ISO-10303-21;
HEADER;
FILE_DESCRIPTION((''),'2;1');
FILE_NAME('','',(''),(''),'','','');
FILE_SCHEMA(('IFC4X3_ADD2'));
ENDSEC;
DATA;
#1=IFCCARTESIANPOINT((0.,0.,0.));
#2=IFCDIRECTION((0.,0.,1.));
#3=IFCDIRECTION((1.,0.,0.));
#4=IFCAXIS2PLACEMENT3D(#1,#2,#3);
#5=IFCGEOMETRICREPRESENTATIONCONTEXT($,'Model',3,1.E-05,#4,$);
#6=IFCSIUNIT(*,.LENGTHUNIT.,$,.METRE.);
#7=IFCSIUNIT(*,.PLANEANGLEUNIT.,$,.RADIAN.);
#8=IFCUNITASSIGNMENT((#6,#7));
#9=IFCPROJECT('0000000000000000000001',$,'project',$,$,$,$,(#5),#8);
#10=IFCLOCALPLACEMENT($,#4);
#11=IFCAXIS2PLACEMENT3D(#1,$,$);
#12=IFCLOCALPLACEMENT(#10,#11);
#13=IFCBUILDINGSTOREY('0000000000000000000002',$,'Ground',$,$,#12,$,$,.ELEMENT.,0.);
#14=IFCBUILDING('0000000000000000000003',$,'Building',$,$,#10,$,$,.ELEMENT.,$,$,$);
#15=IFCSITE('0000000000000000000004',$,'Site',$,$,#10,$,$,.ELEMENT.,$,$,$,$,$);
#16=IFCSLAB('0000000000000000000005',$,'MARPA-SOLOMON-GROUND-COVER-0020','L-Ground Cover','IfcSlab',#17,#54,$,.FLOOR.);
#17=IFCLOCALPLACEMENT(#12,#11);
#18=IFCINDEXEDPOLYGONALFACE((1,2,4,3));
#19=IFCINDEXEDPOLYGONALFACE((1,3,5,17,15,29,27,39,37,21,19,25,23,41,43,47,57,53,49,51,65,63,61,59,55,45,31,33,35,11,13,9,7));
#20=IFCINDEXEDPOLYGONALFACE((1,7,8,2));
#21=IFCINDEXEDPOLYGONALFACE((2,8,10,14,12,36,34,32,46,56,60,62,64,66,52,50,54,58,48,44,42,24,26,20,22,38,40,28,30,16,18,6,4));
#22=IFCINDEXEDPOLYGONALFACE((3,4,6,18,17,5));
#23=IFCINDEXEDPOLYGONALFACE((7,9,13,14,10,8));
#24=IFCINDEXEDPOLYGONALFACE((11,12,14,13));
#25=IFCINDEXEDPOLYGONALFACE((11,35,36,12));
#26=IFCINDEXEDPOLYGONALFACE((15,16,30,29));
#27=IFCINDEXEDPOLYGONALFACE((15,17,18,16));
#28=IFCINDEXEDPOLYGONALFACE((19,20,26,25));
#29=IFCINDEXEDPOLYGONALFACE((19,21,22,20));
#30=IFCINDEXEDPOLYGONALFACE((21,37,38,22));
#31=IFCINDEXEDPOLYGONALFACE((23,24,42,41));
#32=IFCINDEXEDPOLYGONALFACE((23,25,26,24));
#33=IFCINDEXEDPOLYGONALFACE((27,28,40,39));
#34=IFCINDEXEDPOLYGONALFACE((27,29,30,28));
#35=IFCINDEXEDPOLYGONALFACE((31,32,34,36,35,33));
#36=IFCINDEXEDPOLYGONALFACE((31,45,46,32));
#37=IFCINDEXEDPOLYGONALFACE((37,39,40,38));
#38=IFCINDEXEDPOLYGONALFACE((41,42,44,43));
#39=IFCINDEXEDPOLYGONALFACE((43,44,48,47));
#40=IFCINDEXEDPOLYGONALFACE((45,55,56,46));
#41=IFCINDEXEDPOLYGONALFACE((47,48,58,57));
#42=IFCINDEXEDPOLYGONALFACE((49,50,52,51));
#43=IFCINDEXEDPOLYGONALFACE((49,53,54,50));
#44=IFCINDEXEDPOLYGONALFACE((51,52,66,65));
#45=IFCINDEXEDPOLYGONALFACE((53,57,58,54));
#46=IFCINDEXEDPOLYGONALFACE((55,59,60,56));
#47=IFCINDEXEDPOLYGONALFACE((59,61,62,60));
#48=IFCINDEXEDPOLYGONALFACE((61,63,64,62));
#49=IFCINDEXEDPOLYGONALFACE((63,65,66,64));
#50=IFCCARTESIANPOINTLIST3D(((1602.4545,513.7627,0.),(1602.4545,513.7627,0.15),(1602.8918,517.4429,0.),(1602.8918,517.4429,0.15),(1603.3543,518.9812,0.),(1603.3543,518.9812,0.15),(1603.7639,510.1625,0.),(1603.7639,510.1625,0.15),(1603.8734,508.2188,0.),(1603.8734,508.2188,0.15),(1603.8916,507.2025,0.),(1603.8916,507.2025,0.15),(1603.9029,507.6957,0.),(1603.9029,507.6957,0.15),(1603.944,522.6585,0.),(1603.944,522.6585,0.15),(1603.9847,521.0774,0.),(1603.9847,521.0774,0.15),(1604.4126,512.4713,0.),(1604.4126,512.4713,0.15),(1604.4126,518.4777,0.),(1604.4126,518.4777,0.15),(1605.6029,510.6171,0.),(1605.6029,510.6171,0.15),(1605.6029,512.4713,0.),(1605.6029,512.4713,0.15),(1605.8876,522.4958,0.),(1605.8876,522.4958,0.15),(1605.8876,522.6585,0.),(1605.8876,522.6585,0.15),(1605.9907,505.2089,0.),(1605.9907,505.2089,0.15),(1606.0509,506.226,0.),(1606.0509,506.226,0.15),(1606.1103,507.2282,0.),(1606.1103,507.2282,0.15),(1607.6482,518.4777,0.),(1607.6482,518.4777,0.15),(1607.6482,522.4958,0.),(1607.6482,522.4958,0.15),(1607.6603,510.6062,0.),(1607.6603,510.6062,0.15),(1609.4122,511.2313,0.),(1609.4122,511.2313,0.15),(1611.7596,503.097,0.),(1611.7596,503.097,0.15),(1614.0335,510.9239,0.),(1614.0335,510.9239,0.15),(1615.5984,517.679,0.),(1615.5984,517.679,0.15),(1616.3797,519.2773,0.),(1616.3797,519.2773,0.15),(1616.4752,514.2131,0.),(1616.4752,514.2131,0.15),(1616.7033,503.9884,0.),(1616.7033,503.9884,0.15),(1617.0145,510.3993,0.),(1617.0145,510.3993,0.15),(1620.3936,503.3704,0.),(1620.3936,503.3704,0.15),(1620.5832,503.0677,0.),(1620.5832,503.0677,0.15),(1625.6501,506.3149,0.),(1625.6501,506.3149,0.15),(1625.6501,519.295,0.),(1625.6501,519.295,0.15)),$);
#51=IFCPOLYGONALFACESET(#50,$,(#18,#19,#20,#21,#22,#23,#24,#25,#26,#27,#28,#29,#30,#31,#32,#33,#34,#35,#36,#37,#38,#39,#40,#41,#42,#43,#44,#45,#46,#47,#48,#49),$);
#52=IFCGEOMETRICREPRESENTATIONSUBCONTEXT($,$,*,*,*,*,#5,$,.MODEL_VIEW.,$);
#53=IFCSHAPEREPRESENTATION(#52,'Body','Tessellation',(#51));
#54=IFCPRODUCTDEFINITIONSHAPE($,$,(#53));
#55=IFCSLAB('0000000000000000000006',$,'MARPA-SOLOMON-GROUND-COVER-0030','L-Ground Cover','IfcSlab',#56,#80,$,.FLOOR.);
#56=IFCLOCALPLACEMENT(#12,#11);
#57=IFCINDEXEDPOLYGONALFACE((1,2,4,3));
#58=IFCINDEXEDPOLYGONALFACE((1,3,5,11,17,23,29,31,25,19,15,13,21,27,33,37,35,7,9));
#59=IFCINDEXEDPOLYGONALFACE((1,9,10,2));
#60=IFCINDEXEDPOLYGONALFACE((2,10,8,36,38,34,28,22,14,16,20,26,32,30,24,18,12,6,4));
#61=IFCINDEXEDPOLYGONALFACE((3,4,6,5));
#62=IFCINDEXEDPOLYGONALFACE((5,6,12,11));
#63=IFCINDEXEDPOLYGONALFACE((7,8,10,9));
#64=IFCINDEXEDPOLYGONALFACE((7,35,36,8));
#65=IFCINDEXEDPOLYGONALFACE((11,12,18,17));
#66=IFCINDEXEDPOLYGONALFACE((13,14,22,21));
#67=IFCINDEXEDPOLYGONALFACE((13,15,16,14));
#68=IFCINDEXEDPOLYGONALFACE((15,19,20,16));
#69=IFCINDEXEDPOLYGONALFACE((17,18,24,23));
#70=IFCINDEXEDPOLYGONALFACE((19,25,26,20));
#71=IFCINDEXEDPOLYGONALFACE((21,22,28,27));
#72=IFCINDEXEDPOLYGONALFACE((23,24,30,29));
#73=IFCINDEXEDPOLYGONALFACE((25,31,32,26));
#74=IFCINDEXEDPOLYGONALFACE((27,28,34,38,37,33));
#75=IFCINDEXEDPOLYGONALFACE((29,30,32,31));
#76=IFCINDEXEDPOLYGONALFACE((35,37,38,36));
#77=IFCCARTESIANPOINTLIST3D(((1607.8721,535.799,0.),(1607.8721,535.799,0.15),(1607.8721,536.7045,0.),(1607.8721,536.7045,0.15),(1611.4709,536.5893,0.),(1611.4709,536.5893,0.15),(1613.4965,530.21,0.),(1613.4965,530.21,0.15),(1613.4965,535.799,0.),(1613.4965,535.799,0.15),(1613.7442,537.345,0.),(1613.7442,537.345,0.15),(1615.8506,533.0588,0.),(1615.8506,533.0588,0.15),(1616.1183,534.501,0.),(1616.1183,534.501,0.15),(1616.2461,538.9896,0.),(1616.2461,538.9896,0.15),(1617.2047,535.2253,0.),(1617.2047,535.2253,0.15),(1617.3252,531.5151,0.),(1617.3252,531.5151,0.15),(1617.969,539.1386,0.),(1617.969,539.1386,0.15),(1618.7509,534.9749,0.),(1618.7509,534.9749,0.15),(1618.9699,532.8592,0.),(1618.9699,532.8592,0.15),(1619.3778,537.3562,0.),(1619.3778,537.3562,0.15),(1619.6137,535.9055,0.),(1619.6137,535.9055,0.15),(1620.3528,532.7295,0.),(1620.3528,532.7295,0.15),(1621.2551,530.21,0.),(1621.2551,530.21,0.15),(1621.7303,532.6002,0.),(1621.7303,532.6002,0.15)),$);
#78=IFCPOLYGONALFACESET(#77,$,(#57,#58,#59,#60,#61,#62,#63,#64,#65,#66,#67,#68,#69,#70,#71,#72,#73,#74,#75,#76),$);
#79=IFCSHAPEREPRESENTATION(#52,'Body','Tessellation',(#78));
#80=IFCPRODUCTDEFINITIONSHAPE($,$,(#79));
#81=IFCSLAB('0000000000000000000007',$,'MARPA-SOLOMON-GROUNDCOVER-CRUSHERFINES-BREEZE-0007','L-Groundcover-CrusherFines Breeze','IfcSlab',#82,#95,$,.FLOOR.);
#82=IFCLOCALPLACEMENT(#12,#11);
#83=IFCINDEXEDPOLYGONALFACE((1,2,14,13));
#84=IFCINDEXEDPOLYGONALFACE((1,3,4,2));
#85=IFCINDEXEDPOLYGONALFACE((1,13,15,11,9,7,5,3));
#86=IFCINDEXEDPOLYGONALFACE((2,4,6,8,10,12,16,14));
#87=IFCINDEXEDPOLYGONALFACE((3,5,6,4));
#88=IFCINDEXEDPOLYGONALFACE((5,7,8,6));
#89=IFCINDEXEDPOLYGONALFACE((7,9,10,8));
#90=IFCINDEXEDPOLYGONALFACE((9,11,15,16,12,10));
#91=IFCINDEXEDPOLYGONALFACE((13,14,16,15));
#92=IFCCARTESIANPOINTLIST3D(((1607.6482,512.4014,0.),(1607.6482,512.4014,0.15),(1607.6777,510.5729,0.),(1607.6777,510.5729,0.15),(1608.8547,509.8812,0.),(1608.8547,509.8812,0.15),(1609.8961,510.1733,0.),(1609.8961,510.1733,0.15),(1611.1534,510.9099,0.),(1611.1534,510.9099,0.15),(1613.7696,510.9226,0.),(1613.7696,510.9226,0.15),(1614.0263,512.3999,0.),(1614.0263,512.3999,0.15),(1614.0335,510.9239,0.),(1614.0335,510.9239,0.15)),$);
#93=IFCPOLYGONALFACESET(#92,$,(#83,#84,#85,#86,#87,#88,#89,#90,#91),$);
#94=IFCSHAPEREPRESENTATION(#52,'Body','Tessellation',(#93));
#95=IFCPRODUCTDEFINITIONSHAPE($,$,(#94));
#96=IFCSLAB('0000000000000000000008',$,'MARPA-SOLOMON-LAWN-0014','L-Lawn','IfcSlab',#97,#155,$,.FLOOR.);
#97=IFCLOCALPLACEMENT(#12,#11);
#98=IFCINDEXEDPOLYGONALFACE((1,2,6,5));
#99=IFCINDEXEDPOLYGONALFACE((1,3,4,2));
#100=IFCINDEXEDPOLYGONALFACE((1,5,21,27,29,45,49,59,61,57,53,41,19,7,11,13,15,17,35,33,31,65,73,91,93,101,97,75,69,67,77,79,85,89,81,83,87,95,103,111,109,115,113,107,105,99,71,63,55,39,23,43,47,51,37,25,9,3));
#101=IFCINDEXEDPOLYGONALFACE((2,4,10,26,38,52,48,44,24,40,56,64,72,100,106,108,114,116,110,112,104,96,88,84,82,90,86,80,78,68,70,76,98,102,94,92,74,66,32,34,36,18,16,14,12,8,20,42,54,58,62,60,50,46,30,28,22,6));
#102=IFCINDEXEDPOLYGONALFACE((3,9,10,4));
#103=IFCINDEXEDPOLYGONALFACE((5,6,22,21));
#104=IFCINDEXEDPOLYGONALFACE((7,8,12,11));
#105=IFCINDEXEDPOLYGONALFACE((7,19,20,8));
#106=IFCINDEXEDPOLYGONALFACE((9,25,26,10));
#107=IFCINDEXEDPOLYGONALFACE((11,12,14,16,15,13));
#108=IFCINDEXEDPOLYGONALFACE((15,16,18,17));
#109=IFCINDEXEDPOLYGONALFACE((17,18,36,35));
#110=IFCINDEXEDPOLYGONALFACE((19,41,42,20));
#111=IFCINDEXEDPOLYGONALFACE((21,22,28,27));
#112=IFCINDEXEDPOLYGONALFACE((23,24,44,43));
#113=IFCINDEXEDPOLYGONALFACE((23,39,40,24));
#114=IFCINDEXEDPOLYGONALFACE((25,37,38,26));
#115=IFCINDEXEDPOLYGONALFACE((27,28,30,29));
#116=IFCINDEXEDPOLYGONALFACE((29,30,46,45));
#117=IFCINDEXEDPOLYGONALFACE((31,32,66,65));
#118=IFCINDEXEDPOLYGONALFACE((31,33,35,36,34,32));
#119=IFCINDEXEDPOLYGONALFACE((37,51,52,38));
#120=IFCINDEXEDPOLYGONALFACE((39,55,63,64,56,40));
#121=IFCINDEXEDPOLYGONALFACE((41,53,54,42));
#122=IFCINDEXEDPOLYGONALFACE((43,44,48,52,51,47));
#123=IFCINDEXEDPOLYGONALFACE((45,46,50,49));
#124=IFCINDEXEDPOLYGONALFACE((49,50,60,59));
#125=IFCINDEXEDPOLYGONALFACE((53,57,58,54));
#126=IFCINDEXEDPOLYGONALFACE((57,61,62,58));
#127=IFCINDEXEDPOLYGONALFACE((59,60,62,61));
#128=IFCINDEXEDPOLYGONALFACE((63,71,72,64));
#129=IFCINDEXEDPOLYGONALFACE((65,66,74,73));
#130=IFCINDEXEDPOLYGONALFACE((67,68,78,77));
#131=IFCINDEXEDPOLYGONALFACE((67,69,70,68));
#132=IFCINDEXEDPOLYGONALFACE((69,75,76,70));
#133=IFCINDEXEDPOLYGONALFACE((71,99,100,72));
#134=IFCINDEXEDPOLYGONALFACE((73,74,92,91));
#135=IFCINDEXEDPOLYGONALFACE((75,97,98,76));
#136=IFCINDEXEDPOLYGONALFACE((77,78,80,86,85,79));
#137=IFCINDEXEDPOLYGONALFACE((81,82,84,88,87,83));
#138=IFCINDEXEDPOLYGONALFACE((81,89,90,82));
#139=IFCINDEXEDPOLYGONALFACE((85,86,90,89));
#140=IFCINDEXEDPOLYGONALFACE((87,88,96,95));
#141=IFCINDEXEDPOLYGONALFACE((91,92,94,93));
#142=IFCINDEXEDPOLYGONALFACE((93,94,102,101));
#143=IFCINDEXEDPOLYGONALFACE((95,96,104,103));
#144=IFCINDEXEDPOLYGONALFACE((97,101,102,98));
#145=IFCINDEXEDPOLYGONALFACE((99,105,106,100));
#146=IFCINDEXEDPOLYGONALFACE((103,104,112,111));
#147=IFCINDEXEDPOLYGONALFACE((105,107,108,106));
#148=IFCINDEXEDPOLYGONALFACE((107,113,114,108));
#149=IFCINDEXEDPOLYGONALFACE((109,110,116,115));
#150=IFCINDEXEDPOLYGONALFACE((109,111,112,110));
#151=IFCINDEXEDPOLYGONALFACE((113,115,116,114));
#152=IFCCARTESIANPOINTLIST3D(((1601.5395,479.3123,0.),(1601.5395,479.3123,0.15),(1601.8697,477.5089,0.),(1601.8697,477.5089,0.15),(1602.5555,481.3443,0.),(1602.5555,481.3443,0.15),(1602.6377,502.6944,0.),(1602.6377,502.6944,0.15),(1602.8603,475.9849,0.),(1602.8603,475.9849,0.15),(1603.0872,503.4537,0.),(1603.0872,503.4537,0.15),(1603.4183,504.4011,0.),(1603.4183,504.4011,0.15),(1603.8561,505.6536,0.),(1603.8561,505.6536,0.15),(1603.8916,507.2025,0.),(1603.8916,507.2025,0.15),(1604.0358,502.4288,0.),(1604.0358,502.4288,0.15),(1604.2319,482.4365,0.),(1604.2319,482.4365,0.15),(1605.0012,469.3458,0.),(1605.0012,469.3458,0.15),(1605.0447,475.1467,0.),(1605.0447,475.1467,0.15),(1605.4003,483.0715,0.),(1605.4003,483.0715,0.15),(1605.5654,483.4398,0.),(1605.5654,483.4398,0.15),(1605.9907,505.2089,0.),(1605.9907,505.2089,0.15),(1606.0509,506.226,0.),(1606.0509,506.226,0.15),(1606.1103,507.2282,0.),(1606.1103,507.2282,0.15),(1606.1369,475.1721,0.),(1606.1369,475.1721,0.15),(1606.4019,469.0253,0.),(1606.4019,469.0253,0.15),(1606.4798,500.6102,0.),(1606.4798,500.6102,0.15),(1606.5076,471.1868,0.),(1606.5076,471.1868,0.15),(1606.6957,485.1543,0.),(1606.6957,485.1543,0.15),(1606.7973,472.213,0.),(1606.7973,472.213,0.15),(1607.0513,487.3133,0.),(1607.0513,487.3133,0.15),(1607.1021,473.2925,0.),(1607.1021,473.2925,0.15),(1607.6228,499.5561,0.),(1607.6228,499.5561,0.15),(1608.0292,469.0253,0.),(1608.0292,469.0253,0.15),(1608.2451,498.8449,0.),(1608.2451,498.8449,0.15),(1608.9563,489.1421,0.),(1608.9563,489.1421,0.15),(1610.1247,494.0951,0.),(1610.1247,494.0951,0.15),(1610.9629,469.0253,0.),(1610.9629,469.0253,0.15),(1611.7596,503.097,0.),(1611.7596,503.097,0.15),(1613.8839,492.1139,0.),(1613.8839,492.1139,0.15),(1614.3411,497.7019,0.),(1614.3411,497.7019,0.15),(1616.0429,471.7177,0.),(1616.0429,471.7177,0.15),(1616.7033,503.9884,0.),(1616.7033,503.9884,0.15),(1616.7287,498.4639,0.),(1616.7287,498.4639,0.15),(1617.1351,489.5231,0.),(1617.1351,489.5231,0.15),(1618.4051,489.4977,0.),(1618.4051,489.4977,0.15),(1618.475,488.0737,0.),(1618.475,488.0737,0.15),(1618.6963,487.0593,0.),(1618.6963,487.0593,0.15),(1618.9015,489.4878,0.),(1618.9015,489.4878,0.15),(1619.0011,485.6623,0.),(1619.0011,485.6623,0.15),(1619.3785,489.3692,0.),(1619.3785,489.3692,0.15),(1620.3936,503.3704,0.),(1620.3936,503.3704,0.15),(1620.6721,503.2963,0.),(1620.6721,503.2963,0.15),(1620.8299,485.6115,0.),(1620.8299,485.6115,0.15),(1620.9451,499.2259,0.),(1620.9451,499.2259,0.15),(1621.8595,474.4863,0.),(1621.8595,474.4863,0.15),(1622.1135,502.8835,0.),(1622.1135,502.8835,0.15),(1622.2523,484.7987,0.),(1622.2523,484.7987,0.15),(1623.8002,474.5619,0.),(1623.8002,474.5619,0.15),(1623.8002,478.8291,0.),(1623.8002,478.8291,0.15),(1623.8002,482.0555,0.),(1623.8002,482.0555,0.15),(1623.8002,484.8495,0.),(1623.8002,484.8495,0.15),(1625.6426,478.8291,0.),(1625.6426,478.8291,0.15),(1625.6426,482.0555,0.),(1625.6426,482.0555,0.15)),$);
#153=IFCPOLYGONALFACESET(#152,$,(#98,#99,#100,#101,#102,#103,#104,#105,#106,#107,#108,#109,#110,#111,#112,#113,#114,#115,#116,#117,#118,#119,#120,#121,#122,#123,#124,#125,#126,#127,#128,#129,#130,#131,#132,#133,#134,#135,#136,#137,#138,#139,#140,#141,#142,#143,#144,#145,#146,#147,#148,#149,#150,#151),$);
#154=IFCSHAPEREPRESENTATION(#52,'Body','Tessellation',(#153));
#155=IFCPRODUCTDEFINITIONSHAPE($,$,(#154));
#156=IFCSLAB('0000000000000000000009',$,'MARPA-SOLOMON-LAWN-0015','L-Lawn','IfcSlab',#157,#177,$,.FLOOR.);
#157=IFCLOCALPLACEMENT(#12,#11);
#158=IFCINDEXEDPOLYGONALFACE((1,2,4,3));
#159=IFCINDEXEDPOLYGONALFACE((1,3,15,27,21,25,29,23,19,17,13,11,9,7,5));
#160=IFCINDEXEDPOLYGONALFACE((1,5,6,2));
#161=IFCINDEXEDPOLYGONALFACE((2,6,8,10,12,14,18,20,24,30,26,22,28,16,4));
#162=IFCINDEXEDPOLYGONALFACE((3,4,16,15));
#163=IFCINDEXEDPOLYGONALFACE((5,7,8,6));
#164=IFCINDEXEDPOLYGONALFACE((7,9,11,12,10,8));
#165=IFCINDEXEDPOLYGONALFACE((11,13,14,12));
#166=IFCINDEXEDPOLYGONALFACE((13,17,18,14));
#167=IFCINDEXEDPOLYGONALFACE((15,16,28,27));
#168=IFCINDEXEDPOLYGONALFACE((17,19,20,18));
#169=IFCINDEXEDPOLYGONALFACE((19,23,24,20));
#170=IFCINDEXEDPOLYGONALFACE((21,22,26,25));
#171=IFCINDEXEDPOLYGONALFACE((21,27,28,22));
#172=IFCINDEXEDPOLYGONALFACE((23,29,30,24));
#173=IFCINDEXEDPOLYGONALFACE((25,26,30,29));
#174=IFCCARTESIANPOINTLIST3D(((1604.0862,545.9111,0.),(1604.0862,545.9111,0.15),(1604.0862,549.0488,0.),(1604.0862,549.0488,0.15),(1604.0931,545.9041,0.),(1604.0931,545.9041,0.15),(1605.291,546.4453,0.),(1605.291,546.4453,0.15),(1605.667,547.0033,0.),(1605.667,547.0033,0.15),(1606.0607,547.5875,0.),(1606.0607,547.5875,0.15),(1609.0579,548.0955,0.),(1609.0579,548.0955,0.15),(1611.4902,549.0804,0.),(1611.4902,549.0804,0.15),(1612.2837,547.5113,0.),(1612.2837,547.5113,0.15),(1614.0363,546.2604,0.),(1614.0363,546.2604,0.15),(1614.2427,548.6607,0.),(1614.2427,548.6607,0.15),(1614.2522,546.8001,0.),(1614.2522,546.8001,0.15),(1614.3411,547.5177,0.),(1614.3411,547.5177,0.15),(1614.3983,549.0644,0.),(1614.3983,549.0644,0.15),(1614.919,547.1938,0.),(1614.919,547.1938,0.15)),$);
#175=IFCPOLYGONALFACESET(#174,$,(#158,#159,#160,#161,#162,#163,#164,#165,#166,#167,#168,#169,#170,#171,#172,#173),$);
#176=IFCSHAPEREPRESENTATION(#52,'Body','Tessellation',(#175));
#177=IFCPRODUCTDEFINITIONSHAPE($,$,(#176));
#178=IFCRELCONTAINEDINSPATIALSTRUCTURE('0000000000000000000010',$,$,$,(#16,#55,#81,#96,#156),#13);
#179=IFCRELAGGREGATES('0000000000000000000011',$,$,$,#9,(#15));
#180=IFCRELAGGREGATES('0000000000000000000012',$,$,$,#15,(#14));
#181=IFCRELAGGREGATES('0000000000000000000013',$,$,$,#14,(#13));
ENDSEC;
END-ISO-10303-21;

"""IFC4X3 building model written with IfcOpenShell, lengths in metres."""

from ifc_helpers import new_model, si_unit, frame, origin, origin_with_axes, place, context, subcontext, project, spatial, polyline, outline, extrude, element, save


model = new_model("IFC4X3")

# Units and contexts
model_context = context("Model", 3, precision=1e-05, world=origin_with_axes())
sub_context = subcontext(model_context, None, None, "MODEL_VIEW")
ifc_project = project(units=[si_unit("LENGTHUNIT", "METRE"), si_unit("PLANEANGLEUNIT", "RADIAN")], contexts=[model_context])

# Site, building, storey
placement = place(None, origin_with_axes())
site = spatial("IfcSite", under=ifc_project, at=placement, Name="Site", CompositionType="ELEMENT")
building = spatial("IfcBuilding", under=site, at=placement, Name="Building", CompositionType="ELEMENT")
storey_placement = place(placement, origin())
storey = spatial("IfcBuildingStorey", under=building, at=storey_placement, Name="Ground", CompositionType="ELEMENT", Elevation=0.0)

# Slabs
slab_1_placement = place(storey_placement, frame((1602.4545, 503.0677, 0.0)))
element("IfcSlab", 1, at=slab_1_placement, inside=storey, Name="MARPA-SOLOMON-GROUND-COVER-0020", Description="L-Ground Cover", ObjectType="IfcSlab", PredefinedType="FLOOR", context=sub_context, shape_type="SweptSolid", body=[
    extrude(outline(polyline([(1.3094, 7.0948), (1.4189, 5.1511), (1.4484, 4.628), (1.4371, 4.1348), (3.6559, 4.1605), (3.5965, 3.1583), (3.5362, 2.1412), (9.3051, 0.0293), (14.2488, 0.9207), (17.9391, 0.3027), (18.1287, 0.0), (23.1956, 3.2472), (23.1956, 16.2273), (13.9252, 16.2096), (13.1439, 14.6113), (14.0207, 11.1454), (14.56, 7.3316), (11.579, 7.8562), (6.9577, 8.1636), (5.2059, 7.5385), (3.1485, 7.5494), (3.1485, 9.4036), (1.9582, 9.4036), (1.9582, 15.41), (5.1937, 15.41), (5.1937, 19.4281), (3.4331, 19.4281), (3.4331, 19.5908), (1.4895, 19.5908), (1.5302, 18.0097), (0.8999, 15.9135), (0.4373, 14.3752), (0.0, 10.695), (1.3094, 7.0948)])), origin(), (0.0, 0.0, 1.0), 0.15),
])
slab_2_placement = place(storey_placement, frame((1607.8721, 530.21, 0.0)))
element("IfcSlab", 2, at=slab_2_placement, inside=storey, Name="MARPA-SOLOMON-GROUND-COVER-0030", Description="L-Ground Cover", ObjectType="IfcSlab", PredefinedType="FLOOR", context=sub_context, shape_type="SweptSolid", body=[
    extrude(outline(polyline([(13.383, 0.0), (13.8582, 2.3902), (12.4807, 2.5195), (11.0978, 2.6493), (9.4532, 1.3052), (7.9785, 2.8488), (8.2463, 4.291), (9.3326, 5.0153), (10.8788, 4.7649), (11.7417, 5.6955), (11.5058, 7.1463), (10.097, 8.9286), (8.374, 8.7797), (5.8721, 7.135), (3.5988, 6.3794), (0.0, 6.4945), (0.0, 5.589), (5.6245, 5.589), (5.6245, 0.0), (13.383, 0.0)])), origin(), (0.0, 0.0, 1.0), 0.15),
])
slab_3_placement = place(storey_placement, frame((1607.6482, 509.8812, 0.0)))
element("IfcSlab", 3, at=slab_3_placement, inside=storey, Name="MARPA-SOLOMON-GROUNDCOVER-CRUSHERFINES-BREEZE-0007", Description="L-Groundcover-CrusherFines Breeze", ObjectType="IfcSlab", PredefinedType="FLOOR", context=sub_context, shape_type="SweptSolid", body=[
    extrude(outline(polyline([(0.0, 2.5202), (0.0295, 0.6916), (1.2065, 0.0), (2.2479, 0.2921), (3.5052, 1.0287), (6.1214, 1.0414), (6.3853, 1.0427), (6.3781, 2.5186), (0.0, 2.5202)])), origin(), (0.0, 0.0, 1.0), 0.15),
])
slab_4_placement = place(storey_placement, frame((1601.5395, 469.0253, 0.0)))
element("IfcSlab", 4, at=slab_4_placement, inside=storey, Name="MARPA-SOLOMON-LAWN-0014", Description="L-Lawn", ObjectType="IfcSlab", PredefinedType="FLOOR", context=sub_context, shape_type="SweptSolid", body=[
    extrude(outline(polyline([(14.5034, 2.6924), (20.32, 5.461), (22.2607, 5.5366), (22.2607, 9.8038), (24.1031, 9.8038), (24.1031, 13.0302), (22.2607, 13.0302), (22.2607, 15.8242), (20.7128, 15.7734), (19.2904, 16.5862), (17.4616, 16.637), (17.1568, 18.034), (16.9355, 19.0483), (17.839, 20.3439), (17.362, 20.4625), (16.8656, 20.4724), (15.5956, 20.4978), (12.3444, 23.0886), (12.8016, 28.6766), (15.1892, 29.4386), (19.4056, 30.2006), (20.574, 33.8582), (19.1326, 34.2709), (18.8541, 34.3451), (15.1638, 34.9631), (10.2201, 34.0716), (4.4511, 36.1835), (4.5114, 37.2006), (4.5708, 38.2029), (2.3521, 38.1772), (2.3166, 36.6283), (1.8788, 35.3757), (1.5477, 34.4284), (1.0982, 33.669), (2.4963, 33.4034), (4.9403, 31.5849), (6.0833, 30.5308), (6.7056, 29.8196), (8.5852, 25.0698), (7.4168, 20.1168), (5.5118, 18.288), (5.1562, 16.129), (4.0259, 14.4145), (3.8608, 14.0462), (2.6924, 13.4112), (1.016, 12.319), (0.0, 10.287), (0.3302, 8.4836), (1.3208, 6.9596), (3.5052, 6.1214), (4.5974, 6.1468), (5.5626, 4.2672), (5.2578, 3.1877), (4.968, 2.1615), (3.4617, 0.3204), (4.8624, 0.0), (6.4897, 0.0), (9.4234, 0.0), (14.5034, 2.6924)])), origin(), (0.0, 0.0, 1.0), 0.15),
])
slab_5_placement = place(storey_placement, frame((1604.0862, 545.9041, 0.0)))
element("IfcSlab", 5, at=slab_5_placement, inside=storey, Name="MARPA-SOLOMON-LAWN-0015", Description="L-Lawn", ObjectType="IfcSlab", PredefinedType="FLOOR", context=sub_context, shape_type="SweptSolid", body=[
    extrude(outline(polyline([(0.0069, 0.0), (1.2047, 0.5412), (1.5808, 1.0993), (1.9745, 1.6835), (4.9717, 2.1915), (8.1975, 1.6073), (9.9501, 0.3563), (10.166, 0.8961), (10.8327, 1.2898), (10.2549, 1.6136), (10.1565, 2.7566), (10.312, 3.1603), (7.404, 3.1763), (0.0, 3.1447), (0.0, 0.0071), (0.0069, 0.0)])), origin(), (0.0, 0.0, 1.0), 0.15),
])

save(model, "model.ifc")
